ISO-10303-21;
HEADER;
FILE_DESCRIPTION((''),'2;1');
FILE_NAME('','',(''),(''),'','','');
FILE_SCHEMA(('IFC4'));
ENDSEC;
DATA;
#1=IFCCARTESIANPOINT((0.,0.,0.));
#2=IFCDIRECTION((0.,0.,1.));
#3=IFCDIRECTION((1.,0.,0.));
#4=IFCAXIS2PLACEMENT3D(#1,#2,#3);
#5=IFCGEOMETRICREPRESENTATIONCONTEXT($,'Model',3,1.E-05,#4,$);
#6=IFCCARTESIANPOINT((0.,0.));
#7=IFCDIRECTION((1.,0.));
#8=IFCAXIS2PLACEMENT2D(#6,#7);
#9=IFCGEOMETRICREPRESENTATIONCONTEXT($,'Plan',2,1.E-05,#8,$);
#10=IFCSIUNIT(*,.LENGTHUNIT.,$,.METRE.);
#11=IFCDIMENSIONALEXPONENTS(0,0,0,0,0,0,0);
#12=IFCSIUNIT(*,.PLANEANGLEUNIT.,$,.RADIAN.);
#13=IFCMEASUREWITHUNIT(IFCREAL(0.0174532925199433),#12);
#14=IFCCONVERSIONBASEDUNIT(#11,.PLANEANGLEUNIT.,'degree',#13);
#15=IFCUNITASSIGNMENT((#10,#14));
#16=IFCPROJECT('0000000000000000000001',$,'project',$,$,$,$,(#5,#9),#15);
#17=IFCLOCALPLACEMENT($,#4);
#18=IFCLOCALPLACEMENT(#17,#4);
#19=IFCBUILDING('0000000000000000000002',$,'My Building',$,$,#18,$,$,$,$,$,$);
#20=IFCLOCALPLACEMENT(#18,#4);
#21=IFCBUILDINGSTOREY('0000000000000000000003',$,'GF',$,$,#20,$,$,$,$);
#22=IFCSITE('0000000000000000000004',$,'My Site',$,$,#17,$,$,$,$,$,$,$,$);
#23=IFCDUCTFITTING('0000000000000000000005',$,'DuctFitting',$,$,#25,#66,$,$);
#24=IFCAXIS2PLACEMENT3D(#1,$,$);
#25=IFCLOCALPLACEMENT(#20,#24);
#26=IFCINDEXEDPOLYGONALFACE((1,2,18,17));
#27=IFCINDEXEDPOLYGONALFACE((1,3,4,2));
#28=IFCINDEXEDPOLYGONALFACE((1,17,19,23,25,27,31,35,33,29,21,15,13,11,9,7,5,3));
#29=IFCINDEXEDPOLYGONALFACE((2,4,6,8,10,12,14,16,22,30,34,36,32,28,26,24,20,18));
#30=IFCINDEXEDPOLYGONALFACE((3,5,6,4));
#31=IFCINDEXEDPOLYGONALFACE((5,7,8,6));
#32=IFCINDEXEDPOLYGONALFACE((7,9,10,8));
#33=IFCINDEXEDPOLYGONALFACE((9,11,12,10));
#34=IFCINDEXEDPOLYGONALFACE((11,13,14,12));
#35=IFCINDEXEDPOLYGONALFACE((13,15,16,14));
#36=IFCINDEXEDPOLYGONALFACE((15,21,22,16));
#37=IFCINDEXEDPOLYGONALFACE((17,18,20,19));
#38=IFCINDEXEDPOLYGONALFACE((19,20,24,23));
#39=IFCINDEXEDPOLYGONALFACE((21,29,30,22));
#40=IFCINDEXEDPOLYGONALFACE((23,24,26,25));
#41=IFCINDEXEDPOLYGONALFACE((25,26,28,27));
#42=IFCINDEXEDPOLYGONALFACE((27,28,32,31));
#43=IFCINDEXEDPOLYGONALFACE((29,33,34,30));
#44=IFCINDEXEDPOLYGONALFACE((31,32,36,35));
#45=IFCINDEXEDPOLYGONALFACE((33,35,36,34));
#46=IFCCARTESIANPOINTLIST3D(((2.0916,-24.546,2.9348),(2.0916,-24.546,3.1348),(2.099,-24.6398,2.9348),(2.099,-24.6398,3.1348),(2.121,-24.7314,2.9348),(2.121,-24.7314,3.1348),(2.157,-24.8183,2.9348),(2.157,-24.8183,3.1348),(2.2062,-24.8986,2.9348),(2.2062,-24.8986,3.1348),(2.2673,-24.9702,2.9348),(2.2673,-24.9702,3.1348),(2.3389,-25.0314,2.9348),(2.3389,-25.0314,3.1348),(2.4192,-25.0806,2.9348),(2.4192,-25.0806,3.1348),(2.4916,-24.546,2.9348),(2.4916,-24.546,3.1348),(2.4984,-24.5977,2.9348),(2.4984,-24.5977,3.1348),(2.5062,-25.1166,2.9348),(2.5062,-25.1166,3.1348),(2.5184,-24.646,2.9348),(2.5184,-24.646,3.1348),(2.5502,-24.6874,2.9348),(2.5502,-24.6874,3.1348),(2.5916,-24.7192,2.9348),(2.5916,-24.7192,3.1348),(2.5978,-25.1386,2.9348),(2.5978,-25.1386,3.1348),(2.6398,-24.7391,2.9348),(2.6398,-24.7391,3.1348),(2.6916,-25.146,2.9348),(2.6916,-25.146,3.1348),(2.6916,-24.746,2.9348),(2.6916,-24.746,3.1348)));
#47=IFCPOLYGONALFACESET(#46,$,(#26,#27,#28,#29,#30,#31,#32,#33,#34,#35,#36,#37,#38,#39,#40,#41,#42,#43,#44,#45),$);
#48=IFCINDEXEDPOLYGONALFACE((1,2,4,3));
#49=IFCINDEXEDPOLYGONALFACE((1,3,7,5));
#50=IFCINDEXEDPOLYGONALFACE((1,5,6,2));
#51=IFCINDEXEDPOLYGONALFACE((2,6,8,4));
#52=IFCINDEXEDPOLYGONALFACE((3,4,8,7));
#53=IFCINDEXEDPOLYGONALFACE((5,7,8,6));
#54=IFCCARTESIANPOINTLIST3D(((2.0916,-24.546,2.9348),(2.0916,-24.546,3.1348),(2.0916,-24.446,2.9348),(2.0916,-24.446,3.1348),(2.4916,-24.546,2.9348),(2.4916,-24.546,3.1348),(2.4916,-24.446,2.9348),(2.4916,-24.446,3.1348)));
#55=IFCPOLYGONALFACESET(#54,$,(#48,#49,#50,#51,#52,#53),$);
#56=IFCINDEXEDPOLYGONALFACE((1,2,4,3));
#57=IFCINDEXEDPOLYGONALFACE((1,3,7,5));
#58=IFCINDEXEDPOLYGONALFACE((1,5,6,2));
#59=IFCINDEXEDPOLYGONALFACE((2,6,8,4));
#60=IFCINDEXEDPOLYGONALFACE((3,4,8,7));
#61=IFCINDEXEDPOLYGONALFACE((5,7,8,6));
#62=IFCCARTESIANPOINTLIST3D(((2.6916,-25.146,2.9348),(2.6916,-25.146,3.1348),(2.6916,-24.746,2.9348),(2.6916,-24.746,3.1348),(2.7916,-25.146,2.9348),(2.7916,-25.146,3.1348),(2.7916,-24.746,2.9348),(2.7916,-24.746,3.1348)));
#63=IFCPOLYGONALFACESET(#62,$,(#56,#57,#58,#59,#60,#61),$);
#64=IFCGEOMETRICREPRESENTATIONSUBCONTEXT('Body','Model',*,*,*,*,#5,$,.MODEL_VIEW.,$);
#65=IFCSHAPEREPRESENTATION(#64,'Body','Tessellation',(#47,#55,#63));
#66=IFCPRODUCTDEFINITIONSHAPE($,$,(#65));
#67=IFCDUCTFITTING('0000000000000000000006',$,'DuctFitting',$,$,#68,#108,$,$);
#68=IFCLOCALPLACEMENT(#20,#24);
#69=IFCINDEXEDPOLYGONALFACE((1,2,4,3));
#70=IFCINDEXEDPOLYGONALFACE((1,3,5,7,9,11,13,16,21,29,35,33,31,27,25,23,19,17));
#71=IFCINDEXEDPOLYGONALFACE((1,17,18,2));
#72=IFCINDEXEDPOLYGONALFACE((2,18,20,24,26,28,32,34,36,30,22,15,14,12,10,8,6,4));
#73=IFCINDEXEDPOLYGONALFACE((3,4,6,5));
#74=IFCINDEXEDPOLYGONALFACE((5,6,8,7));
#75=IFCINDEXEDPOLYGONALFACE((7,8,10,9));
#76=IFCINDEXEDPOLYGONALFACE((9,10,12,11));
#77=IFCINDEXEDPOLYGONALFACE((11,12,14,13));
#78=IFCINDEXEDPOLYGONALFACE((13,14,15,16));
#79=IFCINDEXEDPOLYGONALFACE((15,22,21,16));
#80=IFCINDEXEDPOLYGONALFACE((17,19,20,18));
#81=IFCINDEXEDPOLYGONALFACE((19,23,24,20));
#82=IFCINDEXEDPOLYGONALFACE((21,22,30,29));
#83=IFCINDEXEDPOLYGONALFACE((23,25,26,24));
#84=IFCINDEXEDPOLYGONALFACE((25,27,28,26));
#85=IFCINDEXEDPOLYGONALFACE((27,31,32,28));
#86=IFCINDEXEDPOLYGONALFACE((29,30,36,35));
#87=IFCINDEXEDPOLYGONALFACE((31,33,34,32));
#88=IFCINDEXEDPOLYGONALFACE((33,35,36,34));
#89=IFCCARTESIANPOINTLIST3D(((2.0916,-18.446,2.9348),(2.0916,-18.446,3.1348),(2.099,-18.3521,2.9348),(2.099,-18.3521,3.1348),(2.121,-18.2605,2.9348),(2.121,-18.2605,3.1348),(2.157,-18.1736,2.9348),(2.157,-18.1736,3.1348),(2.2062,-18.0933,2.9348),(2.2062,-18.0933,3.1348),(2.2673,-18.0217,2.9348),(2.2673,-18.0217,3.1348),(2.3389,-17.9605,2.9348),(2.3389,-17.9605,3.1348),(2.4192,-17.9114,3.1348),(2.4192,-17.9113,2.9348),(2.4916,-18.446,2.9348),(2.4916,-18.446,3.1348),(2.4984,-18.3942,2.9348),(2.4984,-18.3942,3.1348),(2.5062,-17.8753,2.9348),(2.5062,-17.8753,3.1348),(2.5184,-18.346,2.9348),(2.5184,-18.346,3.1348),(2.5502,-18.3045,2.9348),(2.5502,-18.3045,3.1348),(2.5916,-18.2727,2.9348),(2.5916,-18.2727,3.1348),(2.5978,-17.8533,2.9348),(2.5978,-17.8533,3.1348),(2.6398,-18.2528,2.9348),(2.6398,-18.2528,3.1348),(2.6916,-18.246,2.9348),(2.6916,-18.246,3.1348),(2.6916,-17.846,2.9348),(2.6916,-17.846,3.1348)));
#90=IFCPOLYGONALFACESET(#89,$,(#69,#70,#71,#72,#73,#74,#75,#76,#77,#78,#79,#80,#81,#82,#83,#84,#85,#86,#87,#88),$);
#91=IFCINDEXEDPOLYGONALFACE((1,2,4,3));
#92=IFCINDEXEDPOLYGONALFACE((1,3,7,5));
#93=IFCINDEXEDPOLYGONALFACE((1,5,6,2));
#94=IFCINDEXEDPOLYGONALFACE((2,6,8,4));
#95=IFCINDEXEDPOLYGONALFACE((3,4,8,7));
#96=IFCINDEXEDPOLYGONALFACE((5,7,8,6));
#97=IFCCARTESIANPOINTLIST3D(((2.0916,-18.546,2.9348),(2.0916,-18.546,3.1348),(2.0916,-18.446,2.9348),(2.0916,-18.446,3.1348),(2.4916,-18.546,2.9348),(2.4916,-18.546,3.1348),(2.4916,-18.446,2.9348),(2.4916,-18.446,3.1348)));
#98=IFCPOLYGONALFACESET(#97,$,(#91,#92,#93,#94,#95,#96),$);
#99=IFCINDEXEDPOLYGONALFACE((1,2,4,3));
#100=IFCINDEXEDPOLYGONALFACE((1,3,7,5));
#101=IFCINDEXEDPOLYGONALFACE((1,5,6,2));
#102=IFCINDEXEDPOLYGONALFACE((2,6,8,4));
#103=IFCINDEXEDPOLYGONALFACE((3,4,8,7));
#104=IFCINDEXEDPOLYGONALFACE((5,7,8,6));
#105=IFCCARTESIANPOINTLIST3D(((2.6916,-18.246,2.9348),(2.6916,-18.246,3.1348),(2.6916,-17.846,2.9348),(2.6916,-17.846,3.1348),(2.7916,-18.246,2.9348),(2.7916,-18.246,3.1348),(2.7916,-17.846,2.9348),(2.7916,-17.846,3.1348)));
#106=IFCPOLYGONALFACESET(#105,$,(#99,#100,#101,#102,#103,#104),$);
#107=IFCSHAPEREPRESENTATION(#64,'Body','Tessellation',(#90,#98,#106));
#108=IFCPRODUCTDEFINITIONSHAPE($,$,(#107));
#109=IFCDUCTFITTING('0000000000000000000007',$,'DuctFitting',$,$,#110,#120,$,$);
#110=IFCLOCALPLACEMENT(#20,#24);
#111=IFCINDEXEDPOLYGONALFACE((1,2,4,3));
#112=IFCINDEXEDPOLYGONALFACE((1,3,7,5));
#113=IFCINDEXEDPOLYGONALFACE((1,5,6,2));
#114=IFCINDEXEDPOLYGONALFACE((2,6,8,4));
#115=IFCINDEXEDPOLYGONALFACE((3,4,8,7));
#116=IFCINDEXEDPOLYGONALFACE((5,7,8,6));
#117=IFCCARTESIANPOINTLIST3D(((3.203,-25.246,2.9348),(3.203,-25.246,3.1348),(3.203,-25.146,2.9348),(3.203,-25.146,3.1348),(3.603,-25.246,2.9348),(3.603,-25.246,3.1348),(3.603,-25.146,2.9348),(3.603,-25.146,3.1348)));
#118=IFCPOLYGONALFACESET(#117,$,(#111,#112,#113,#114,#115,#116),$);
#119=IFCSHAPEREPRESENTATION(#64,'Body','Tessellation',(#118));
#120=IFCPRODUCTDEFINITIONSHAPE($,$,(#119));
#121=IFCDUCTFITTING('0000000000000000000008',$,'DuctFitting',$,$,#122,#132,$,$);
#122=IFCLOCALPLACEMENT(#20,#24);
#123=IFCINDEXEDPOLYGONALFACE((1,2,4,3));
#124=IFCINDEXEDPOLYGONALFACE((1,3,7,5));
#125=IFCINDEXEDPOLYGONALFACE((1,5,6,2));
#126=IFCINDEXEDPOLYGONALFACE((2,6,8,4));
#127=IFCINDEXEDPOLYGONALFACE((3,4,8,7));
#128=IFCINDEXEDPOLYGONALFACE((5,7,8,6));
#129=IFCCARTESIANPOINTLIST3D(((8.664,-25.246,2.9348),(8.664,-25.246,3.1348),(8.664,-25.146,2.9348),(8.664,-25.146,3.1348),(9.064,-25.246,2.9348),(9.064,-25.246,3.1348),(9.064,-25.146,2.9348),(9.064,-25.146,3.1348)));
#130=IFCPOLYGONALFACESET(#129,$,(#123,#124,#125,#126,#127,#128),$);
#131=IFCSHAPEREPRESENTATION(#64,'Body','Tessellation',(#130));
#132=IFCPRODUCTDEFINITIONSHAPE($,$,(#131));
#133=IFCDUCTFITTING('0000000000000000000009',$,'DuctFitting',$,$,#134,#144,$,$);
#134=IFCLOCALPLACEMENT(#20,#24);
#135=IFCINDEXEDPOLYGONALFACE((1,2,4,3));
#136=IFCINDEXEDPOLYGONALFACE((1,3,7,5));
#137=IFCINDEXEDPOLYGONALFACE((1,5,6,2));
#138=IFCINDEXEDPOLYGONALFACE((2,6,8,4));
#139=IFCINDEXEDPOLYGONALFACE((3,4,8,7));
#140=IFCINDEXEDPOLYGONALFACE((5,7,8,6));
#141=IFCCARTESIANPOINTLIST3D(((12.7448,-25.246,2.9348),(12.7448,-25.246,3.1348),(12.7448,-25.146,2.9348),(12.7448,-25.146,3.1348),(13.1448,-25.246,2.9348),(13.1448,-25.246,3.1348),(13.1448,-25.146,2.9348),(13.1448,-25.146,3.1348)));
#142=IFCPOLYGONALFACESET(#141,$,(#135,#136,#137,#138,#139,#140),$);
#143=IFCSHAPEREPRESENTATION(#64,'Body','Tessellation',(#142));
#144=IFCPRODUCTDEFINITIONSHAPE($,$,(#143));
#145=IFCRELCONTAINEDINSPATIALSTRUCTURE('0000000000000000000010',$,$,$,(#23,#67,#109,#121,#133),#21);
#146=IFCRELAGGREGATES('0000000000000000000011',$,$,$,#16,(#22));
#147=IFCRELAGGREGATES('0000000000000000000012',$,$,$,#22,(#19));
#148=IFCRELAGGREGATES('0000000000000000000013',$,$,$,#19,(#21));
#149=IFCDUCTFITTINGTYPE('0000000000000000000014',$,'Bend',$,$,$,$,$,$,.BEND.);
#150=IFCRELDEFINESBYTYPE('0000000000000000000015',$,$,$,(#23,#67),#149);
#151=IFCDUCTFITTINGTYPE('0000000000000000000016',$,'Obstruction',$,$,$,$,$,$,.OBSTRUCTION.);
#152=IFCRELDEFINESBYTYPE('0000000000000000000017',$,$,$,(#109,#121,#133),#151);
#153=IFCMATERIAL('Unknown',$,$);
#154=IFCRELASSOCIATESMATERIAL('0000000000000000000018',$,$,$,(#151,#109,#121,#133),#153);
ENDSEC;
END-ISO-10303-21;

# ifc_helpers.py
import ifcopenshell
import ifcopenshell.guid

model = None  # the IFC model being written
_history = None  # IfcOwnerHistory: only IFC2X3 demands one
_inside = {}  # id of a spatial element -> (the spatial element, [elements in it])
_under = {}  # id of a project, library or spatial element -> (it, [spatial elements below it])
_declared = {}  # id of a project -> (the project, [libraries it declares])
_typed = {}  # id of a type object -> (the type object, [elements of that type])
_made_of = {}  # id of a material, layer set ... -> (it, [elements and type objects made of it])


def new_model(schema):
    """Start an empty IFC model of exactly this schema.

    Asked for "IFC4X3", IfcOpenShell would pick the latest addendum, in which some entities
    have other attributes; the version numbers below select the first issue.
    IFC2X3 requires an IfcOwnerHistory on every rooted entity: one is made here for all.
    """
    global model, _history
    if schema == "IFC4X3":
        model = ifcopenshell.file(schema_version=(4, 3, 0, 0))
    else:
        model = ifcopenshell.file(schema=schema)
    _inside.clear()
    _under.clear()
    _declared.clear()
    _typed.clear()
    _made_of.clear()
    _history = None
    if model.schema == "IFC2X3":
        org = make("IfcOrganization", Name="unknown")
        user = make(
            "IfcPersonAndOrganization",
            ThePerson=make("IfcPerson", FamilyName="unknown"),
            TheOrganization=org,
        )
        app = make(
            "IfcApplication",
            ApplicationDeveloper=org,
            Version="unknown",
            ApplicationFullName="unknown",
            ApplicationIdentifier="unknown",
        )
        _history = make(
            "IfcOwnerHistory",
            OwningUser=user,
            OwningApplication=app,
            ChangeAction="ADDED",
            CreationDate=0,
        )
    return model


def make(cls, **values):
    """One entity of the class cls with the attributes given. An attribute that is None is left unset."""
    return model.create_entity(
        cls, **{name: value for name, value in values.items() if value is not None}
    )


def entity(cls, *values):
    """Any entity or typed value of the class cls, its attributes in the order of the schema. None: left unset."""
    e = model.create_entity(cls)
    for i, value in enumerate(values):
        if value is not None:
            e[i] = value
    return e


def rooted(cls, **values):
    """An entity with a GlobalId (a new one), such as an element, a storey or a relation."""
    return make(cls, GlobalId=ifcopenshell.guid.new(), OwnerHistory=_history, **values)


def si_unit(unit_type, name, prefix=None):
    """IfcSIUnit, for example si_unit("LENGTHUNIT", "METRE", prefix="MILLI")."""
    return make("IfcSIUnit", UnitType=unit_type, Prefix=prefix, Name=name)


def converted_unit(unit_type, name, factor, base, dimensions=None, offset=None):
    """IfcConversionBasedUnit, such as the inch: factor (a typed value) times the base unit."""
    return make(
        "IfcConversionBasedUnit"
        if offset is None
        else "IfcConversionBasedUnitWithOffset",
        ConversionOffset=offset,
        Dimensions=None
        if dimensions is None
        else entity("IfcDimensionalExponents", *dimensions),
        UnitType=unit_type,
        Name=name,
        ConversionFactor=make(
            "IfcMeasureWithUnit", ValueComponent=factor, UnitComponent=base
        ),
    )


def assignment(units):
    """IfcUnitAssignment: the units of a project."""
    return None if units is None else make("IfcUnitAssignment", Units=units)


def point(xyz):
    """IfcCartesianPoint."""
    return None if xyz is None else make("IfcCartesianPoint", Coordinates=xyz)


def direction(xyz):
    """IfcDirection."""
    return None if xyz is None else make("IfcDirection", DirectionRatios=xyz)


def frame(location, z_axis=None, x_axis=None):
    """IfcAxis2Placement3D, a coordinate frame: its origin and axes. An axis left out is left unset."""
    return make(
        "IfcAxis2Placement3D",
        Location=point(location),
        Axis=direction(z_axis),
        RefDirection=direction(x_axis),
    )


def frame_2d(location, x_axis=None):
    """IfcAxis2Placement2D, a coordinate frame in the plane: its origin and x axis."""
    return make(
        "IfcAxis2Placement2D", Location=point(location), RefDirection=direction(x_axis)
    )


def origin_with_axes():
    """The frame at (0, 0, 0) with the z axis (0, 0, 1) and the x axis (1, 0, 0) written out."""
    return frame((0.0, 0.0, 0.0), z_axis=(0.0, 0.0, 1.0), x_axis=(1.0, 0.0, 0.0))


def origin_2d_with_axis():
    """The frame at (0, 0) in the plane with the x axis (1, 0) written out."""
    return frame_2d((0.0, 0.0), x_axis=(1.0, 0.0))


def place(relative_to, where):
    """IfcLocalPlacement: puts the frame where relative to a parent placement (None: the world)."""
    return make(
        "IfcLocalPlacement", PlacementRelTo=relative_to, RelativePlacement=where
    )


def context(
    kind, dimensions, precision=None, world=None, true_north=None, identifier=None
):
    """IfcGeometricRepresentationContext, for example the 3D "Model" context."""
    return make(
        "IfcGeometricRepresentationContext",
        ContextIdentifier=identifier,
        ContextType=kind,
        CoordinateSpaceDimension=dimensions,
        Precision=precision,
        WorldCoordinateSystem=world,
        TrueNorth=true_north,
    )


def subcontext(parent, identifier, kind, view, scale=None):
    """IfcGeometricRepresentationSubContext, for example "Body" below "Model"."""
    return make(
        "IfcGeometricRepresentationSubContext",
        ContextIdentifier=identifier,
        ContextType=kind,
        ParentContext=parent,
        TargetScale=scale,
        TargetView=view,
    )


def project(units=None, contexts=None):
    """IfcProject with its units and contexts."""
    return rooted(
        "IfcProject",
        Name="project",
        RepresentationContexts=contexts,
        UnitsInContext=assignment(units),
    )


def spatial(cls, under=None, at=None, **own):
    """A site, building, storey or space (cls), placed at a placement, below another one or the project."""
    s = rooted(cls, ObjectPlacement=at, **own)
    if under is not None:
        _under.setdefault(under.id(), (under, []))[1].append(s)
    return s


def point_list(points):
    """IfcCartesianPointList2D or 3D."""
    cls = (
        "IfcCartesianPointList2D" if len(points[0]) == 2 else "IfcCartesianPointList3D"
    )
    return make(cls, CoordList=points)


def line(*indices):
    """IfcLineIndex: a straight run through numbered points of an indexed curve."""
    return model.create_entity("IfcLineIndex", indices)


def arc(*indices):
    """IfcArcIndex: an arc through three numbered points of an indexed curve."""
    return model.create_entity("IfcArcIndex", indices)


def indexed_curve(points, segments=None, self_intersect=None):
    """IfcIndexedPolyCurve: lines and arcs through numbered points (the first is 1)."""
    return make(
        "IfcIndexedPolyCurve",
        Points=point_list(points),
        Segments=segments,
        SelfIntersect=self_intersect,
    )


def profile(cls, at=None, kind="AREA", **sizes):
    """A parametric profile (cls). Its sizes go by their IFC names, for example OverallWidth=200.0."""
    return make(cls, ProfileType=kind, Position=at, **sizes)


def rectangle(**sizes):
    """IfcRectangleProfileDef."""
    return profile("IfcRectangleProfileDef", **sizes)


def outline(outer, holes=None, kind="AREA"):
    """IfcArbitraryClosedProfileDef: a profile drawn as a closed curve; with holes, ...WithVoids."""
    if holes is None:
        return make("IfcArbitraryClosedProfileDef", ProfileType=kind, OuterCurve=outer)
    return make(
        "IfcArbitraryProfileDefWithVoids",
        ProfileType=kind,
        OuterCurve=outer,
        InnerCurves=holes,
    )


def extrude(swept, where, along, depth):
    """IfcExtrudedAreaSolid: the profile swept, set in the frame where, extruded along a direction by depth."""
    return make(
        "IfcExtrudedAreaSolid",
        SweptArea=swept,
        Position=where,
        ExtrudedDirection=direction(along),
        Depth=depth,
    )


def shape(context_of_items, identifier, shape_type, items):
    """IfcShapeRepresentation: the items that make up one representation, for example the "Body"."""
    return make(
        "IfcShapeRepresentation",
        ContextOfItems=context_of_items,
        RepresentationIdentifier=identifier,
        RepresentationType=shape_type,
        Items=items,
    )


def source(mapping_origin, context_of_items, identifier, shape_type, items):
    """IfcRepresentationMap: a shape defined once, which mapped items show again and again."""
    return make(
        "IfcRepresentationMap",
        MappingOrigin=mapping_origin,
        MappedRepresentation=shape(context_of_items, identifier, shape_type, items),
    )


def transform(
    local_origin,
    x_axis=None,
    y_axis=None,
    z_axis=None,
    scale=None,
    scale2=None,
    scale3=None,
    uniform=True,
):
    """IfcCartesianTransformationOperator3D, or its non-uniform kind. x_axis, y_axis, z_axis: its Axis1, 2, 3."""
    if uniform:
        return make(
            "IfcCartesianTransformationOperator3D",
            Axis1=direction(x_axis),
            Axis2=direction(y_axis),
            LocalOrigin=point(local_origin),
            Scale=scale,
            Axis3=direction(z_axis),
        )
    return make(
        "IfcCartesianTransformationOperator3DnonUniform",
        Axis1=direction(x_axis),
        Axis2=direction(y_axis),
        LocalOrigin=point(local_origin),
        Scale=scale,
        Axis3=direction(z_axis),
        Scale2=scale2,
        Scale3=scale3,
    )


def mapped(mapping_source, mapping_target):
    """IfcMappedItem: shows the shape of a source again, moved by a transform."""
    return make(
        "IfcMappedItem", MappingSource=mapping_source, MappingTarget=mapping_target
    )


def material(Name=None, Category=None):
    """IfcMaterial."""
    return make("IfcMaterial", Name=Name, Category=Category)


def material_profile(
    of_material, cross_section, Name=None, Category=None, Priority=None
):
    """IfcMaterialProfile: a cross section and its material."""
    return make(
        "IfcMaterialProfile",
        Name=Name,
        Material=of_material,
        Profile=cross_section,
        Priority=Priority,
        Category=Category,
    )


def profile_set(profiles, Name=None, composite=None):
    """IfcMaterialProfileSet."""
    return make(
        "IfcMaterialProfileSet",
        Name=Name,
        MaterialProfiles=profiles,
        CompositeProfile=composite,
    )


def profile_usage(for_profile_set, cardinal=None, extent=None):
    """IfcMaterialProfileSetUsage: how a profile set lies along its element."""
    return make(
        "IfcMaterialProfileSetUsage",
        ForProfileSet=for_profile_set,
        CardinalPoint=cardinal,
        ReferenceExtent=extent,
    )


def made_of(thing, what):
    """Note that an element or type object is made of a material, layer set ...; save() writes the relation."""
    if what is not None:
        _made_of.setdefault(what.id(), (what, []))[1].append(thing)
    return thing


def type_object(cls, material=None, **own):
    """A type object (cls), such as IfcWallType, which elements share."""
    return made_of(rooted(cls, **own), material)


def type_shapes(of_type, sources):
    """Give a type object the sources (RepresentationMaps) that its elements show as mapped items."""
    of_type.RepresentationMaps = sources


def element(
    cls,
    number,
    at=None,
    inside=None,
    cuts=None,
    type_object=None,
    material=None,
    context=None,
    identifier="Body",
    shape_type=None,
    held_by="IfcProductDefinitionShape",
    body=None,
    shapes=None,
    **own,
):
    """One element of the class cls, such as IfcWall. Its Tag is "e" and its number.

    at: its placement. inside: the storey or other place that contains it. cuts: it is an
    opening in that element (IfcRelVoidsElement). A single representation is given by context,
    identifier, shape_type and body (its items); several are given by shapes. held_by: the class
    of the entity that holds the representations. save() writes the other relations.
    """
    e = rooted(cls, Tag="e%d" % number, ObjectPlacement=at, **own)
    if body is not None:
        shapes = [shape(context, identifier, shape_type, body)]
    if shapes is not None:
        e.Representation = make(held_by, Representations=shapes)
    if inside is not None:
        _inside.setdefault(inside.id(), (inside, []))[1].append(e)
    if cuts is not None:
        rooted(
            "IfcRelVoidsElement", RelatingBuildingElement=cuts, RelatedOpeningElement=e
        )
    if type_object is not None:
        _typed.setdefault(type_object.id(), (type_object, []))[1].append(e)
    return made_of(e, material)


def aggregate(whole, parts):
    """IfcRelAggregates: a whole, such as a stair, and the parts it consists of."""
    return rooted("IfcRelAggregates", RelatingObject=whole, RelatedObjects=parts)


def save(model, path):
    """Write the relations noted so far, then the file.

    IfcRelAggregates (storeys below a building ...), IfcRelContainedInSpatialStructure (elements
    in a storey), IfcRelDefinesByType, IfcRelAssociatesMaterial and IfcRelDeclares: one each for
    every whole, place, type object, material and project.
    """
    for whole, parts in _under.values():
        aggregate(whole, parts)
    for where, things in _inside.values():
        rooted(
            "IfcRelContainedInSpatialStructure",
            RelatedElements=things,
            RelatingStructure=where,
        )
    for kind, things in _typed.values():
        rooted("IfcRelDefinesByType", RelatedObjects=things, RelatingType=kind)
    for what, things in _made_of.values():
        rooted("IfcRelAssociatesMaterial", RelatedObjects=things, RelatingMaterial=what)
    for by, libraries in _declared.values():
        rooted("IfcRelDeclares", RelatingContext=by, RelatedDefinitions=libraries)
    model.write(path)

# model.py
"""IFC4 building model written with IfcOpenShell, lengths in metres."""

from ifc_helpers import new_model, entity, si_unit, converted_unit, frame, origin_with_axes, origin_2d_with_axis, place, context, subcontext, project, spatial, line, arc, indexed_curve, rectangle, outline, extrude, source, transform, mapped, material, material_profile, profile_set, profile_usage, type_object, type_shapes, element, save


model = new_model("IFC4")

# Units and contexts
model_context = context("Model", 3, precision=1e-05, world=origin_with_axes())
plan_context = context("Plan", 2, precision=1e-05, world=origin_2d_with_axis())
body_context_1 = subcontext(model_context, "Body", "Model", "MODEL_VIEW")
ifc_project = project(units=[si_unit("LENGTHUNIT", "METRE"), converted_unit("PLANEANGLEUNIT", "degree", entity("IfcReal", 0.0174532925199433), si_unit("PLANEANGLEUNIT", "RADIAN"), dimensions=[0, 0, 0, 0, 0, 0, 0])], contexts=[model_context, plan_context])

# Site, building, storey
site_placement = place(None, origin_with_axes())
site = spatial("IfcSite", under=ifc_project, at=site_placement, Name="My Site")
building_placement = place(site_placement, origin_with_axes())
building = spatial("IfcBuilding", under=site, at=building_placement, Name="My Building")
storey_placement = place(building_placement, origin_with_axes())
storey = spatial("IfcBuildingStorey", under=building, at=storey_placement, Name="GF")

# Shared definitions
ifc_material = material(Name="Unknown")

# Duct fittings
duct_fitting_type_1 = type_object("IfcDuctFittingType", Name="Bend", PredefinedType="BEND")
shared_shape_1 = source(origin_with_axes(), body_context_1, "Body", "SweptSolid", [
    extrude(outline(indexed_curve([(0.2, 0.0), (0.2586, 0.1414), (0.4, 0.2), (0.4, 0.6), (-0.0243, 0.4243), (-0.2, 0.0)], segments=[arc(1, 2, 3), line(3, 4), arc(4, 5, 6), line(6, 1)])), frame((0.0, -0.1, 0.1), z_axis=(0.0, -1.0, 0.0), x_axis=(1.0, 0.0, 0.0)), (0.0, 0.0, -1.0), 0.2),
    extrude(rectangle(XDim=0.4, YDim=0.2), origin_with_axes(), (0.0, 0.0, 1.0), 0.1),
    extrude(rectangle(XDim=0.4, YDim=0.2), frame((0.4, 0.0, 0.5), z_axis=(1.0, 0.0, 0.0), x_axis=(0.0, 0.0, 1.0)), (0.0, 0.0, 1.0), 0.1),
])
type_shapes(duct_fitting_type_1, [shared_shape_1])
for number, where, z_axis, x_axis, name in (
    (1, (2.2916, -24.446, 3.0348), (0.0, -1.0, -0.000002), (1.0, 0.0, 0.0), "DuctFitting"),
    (2, (2.2916, -18.546, 3.0348), (0.0, 1.0, 0.000002), (1.0, 0.0, 0.0), "DuctFitting"),
):
    element("IfcDuctFitting", number, at=place(storey_placement, frame(where, z_axis=z_axis, x_axis=x_axis)), inside=storey, type_object=duct_fitting_type_1, Name=name, context=body_context_1, shape_type="MappedRepresentation", body=[
        mapped(shared_shape_1, transform((0.0, 0.0, 0.0), x_axis=(1.0, 0.0, 0.0), y_axis=(0.0, 1.0, 0.0), z_axis=(0.0, 0.0, 1.0), scale=1.0)),
    ])
ifc_material_profile_1 = material_profile(ifc_material, rectangle(XDim=0.4, YDim=0.2))
ifc_profile_set_1 = profile_set([ifc_material_profile_1])
ifc_profile_usage_1 = profile_usage(ifc_profile_set_1, cardinal=5)
duct_fitting_type_2 = type_object("IfcDuctFittingType", Name="Obstruction", PredefinedType="OBSTRUCTION", material=ifc_profile_set_1)
duct_fitting_1_placement = place(storey_placement, frame((3.403, -25.146, 3.0348), z_axis=(0.0, -1.0, 0.000001), x_axis=(1.0, 0.0, 0.0)))
element("IfcDuctFitting", 3, at=duct_fitting_1_placement, inside=storey, type_object=duct_fitting_type_2, material=ifc_profile_usage_1, Name="DuctFitting", context=body_context_1, shape_type="SweptSolid", body=[
    extrude(rectangle(XDim=0.4, YDim=0.2), origin_with_axes(), (0.0, 0.0, 1.0), 0.1),
])
ifc_profile_usage_2 = profile_usage(ifc_profile_set_1, cardinal=5)
duct_fitting_2_placement = place(storey_placement, frame((8.864, -25.146, 3.0348), z_axis=(0.0, -1.0, 0.000001), x_axis=(1.0, 0.0, 0.0)))
element("IfcDuctFitting", 4, at=duct_fitting_2_placement, inside=storey, type_object=duct_fitting_type_2, material=ifc_profile_usage_2, Name="DuctFitting", context=body_context_1, shape_type="SweptSolid", body=[
    extrude(rectangle(XDim=0.4, YDim=0.2), origin_with_axes(), (0.0, 0.0, 1.0), 0.1),
])
ifc_profile_usage_3 = profile_usage(ifc_profile_set_1, cardinal=5)
duct_fitting_3_placement = place(storey_placement, frame((12.9448, -25.146, 3.0348), z_axis=(0.0, -1.0, 0.000001), x_axis=(1.0, 0.0, 0.0)))
element("IfcDuctFitting", 5, at=duct_fitting_3_placement, inside=storey, type_object=duct_fitting_type_2, material=ifc_profile_usage_3, Name="DuctFitting", context=body_context_1, shape_type="SweptSolid", body=[
    extrude(rectangle(XDim=0.4, YDim=0.2), origin_with_axes(), (0.0, 0.0, 1.0), 0.1),
])

save(model, "model.ifc")
